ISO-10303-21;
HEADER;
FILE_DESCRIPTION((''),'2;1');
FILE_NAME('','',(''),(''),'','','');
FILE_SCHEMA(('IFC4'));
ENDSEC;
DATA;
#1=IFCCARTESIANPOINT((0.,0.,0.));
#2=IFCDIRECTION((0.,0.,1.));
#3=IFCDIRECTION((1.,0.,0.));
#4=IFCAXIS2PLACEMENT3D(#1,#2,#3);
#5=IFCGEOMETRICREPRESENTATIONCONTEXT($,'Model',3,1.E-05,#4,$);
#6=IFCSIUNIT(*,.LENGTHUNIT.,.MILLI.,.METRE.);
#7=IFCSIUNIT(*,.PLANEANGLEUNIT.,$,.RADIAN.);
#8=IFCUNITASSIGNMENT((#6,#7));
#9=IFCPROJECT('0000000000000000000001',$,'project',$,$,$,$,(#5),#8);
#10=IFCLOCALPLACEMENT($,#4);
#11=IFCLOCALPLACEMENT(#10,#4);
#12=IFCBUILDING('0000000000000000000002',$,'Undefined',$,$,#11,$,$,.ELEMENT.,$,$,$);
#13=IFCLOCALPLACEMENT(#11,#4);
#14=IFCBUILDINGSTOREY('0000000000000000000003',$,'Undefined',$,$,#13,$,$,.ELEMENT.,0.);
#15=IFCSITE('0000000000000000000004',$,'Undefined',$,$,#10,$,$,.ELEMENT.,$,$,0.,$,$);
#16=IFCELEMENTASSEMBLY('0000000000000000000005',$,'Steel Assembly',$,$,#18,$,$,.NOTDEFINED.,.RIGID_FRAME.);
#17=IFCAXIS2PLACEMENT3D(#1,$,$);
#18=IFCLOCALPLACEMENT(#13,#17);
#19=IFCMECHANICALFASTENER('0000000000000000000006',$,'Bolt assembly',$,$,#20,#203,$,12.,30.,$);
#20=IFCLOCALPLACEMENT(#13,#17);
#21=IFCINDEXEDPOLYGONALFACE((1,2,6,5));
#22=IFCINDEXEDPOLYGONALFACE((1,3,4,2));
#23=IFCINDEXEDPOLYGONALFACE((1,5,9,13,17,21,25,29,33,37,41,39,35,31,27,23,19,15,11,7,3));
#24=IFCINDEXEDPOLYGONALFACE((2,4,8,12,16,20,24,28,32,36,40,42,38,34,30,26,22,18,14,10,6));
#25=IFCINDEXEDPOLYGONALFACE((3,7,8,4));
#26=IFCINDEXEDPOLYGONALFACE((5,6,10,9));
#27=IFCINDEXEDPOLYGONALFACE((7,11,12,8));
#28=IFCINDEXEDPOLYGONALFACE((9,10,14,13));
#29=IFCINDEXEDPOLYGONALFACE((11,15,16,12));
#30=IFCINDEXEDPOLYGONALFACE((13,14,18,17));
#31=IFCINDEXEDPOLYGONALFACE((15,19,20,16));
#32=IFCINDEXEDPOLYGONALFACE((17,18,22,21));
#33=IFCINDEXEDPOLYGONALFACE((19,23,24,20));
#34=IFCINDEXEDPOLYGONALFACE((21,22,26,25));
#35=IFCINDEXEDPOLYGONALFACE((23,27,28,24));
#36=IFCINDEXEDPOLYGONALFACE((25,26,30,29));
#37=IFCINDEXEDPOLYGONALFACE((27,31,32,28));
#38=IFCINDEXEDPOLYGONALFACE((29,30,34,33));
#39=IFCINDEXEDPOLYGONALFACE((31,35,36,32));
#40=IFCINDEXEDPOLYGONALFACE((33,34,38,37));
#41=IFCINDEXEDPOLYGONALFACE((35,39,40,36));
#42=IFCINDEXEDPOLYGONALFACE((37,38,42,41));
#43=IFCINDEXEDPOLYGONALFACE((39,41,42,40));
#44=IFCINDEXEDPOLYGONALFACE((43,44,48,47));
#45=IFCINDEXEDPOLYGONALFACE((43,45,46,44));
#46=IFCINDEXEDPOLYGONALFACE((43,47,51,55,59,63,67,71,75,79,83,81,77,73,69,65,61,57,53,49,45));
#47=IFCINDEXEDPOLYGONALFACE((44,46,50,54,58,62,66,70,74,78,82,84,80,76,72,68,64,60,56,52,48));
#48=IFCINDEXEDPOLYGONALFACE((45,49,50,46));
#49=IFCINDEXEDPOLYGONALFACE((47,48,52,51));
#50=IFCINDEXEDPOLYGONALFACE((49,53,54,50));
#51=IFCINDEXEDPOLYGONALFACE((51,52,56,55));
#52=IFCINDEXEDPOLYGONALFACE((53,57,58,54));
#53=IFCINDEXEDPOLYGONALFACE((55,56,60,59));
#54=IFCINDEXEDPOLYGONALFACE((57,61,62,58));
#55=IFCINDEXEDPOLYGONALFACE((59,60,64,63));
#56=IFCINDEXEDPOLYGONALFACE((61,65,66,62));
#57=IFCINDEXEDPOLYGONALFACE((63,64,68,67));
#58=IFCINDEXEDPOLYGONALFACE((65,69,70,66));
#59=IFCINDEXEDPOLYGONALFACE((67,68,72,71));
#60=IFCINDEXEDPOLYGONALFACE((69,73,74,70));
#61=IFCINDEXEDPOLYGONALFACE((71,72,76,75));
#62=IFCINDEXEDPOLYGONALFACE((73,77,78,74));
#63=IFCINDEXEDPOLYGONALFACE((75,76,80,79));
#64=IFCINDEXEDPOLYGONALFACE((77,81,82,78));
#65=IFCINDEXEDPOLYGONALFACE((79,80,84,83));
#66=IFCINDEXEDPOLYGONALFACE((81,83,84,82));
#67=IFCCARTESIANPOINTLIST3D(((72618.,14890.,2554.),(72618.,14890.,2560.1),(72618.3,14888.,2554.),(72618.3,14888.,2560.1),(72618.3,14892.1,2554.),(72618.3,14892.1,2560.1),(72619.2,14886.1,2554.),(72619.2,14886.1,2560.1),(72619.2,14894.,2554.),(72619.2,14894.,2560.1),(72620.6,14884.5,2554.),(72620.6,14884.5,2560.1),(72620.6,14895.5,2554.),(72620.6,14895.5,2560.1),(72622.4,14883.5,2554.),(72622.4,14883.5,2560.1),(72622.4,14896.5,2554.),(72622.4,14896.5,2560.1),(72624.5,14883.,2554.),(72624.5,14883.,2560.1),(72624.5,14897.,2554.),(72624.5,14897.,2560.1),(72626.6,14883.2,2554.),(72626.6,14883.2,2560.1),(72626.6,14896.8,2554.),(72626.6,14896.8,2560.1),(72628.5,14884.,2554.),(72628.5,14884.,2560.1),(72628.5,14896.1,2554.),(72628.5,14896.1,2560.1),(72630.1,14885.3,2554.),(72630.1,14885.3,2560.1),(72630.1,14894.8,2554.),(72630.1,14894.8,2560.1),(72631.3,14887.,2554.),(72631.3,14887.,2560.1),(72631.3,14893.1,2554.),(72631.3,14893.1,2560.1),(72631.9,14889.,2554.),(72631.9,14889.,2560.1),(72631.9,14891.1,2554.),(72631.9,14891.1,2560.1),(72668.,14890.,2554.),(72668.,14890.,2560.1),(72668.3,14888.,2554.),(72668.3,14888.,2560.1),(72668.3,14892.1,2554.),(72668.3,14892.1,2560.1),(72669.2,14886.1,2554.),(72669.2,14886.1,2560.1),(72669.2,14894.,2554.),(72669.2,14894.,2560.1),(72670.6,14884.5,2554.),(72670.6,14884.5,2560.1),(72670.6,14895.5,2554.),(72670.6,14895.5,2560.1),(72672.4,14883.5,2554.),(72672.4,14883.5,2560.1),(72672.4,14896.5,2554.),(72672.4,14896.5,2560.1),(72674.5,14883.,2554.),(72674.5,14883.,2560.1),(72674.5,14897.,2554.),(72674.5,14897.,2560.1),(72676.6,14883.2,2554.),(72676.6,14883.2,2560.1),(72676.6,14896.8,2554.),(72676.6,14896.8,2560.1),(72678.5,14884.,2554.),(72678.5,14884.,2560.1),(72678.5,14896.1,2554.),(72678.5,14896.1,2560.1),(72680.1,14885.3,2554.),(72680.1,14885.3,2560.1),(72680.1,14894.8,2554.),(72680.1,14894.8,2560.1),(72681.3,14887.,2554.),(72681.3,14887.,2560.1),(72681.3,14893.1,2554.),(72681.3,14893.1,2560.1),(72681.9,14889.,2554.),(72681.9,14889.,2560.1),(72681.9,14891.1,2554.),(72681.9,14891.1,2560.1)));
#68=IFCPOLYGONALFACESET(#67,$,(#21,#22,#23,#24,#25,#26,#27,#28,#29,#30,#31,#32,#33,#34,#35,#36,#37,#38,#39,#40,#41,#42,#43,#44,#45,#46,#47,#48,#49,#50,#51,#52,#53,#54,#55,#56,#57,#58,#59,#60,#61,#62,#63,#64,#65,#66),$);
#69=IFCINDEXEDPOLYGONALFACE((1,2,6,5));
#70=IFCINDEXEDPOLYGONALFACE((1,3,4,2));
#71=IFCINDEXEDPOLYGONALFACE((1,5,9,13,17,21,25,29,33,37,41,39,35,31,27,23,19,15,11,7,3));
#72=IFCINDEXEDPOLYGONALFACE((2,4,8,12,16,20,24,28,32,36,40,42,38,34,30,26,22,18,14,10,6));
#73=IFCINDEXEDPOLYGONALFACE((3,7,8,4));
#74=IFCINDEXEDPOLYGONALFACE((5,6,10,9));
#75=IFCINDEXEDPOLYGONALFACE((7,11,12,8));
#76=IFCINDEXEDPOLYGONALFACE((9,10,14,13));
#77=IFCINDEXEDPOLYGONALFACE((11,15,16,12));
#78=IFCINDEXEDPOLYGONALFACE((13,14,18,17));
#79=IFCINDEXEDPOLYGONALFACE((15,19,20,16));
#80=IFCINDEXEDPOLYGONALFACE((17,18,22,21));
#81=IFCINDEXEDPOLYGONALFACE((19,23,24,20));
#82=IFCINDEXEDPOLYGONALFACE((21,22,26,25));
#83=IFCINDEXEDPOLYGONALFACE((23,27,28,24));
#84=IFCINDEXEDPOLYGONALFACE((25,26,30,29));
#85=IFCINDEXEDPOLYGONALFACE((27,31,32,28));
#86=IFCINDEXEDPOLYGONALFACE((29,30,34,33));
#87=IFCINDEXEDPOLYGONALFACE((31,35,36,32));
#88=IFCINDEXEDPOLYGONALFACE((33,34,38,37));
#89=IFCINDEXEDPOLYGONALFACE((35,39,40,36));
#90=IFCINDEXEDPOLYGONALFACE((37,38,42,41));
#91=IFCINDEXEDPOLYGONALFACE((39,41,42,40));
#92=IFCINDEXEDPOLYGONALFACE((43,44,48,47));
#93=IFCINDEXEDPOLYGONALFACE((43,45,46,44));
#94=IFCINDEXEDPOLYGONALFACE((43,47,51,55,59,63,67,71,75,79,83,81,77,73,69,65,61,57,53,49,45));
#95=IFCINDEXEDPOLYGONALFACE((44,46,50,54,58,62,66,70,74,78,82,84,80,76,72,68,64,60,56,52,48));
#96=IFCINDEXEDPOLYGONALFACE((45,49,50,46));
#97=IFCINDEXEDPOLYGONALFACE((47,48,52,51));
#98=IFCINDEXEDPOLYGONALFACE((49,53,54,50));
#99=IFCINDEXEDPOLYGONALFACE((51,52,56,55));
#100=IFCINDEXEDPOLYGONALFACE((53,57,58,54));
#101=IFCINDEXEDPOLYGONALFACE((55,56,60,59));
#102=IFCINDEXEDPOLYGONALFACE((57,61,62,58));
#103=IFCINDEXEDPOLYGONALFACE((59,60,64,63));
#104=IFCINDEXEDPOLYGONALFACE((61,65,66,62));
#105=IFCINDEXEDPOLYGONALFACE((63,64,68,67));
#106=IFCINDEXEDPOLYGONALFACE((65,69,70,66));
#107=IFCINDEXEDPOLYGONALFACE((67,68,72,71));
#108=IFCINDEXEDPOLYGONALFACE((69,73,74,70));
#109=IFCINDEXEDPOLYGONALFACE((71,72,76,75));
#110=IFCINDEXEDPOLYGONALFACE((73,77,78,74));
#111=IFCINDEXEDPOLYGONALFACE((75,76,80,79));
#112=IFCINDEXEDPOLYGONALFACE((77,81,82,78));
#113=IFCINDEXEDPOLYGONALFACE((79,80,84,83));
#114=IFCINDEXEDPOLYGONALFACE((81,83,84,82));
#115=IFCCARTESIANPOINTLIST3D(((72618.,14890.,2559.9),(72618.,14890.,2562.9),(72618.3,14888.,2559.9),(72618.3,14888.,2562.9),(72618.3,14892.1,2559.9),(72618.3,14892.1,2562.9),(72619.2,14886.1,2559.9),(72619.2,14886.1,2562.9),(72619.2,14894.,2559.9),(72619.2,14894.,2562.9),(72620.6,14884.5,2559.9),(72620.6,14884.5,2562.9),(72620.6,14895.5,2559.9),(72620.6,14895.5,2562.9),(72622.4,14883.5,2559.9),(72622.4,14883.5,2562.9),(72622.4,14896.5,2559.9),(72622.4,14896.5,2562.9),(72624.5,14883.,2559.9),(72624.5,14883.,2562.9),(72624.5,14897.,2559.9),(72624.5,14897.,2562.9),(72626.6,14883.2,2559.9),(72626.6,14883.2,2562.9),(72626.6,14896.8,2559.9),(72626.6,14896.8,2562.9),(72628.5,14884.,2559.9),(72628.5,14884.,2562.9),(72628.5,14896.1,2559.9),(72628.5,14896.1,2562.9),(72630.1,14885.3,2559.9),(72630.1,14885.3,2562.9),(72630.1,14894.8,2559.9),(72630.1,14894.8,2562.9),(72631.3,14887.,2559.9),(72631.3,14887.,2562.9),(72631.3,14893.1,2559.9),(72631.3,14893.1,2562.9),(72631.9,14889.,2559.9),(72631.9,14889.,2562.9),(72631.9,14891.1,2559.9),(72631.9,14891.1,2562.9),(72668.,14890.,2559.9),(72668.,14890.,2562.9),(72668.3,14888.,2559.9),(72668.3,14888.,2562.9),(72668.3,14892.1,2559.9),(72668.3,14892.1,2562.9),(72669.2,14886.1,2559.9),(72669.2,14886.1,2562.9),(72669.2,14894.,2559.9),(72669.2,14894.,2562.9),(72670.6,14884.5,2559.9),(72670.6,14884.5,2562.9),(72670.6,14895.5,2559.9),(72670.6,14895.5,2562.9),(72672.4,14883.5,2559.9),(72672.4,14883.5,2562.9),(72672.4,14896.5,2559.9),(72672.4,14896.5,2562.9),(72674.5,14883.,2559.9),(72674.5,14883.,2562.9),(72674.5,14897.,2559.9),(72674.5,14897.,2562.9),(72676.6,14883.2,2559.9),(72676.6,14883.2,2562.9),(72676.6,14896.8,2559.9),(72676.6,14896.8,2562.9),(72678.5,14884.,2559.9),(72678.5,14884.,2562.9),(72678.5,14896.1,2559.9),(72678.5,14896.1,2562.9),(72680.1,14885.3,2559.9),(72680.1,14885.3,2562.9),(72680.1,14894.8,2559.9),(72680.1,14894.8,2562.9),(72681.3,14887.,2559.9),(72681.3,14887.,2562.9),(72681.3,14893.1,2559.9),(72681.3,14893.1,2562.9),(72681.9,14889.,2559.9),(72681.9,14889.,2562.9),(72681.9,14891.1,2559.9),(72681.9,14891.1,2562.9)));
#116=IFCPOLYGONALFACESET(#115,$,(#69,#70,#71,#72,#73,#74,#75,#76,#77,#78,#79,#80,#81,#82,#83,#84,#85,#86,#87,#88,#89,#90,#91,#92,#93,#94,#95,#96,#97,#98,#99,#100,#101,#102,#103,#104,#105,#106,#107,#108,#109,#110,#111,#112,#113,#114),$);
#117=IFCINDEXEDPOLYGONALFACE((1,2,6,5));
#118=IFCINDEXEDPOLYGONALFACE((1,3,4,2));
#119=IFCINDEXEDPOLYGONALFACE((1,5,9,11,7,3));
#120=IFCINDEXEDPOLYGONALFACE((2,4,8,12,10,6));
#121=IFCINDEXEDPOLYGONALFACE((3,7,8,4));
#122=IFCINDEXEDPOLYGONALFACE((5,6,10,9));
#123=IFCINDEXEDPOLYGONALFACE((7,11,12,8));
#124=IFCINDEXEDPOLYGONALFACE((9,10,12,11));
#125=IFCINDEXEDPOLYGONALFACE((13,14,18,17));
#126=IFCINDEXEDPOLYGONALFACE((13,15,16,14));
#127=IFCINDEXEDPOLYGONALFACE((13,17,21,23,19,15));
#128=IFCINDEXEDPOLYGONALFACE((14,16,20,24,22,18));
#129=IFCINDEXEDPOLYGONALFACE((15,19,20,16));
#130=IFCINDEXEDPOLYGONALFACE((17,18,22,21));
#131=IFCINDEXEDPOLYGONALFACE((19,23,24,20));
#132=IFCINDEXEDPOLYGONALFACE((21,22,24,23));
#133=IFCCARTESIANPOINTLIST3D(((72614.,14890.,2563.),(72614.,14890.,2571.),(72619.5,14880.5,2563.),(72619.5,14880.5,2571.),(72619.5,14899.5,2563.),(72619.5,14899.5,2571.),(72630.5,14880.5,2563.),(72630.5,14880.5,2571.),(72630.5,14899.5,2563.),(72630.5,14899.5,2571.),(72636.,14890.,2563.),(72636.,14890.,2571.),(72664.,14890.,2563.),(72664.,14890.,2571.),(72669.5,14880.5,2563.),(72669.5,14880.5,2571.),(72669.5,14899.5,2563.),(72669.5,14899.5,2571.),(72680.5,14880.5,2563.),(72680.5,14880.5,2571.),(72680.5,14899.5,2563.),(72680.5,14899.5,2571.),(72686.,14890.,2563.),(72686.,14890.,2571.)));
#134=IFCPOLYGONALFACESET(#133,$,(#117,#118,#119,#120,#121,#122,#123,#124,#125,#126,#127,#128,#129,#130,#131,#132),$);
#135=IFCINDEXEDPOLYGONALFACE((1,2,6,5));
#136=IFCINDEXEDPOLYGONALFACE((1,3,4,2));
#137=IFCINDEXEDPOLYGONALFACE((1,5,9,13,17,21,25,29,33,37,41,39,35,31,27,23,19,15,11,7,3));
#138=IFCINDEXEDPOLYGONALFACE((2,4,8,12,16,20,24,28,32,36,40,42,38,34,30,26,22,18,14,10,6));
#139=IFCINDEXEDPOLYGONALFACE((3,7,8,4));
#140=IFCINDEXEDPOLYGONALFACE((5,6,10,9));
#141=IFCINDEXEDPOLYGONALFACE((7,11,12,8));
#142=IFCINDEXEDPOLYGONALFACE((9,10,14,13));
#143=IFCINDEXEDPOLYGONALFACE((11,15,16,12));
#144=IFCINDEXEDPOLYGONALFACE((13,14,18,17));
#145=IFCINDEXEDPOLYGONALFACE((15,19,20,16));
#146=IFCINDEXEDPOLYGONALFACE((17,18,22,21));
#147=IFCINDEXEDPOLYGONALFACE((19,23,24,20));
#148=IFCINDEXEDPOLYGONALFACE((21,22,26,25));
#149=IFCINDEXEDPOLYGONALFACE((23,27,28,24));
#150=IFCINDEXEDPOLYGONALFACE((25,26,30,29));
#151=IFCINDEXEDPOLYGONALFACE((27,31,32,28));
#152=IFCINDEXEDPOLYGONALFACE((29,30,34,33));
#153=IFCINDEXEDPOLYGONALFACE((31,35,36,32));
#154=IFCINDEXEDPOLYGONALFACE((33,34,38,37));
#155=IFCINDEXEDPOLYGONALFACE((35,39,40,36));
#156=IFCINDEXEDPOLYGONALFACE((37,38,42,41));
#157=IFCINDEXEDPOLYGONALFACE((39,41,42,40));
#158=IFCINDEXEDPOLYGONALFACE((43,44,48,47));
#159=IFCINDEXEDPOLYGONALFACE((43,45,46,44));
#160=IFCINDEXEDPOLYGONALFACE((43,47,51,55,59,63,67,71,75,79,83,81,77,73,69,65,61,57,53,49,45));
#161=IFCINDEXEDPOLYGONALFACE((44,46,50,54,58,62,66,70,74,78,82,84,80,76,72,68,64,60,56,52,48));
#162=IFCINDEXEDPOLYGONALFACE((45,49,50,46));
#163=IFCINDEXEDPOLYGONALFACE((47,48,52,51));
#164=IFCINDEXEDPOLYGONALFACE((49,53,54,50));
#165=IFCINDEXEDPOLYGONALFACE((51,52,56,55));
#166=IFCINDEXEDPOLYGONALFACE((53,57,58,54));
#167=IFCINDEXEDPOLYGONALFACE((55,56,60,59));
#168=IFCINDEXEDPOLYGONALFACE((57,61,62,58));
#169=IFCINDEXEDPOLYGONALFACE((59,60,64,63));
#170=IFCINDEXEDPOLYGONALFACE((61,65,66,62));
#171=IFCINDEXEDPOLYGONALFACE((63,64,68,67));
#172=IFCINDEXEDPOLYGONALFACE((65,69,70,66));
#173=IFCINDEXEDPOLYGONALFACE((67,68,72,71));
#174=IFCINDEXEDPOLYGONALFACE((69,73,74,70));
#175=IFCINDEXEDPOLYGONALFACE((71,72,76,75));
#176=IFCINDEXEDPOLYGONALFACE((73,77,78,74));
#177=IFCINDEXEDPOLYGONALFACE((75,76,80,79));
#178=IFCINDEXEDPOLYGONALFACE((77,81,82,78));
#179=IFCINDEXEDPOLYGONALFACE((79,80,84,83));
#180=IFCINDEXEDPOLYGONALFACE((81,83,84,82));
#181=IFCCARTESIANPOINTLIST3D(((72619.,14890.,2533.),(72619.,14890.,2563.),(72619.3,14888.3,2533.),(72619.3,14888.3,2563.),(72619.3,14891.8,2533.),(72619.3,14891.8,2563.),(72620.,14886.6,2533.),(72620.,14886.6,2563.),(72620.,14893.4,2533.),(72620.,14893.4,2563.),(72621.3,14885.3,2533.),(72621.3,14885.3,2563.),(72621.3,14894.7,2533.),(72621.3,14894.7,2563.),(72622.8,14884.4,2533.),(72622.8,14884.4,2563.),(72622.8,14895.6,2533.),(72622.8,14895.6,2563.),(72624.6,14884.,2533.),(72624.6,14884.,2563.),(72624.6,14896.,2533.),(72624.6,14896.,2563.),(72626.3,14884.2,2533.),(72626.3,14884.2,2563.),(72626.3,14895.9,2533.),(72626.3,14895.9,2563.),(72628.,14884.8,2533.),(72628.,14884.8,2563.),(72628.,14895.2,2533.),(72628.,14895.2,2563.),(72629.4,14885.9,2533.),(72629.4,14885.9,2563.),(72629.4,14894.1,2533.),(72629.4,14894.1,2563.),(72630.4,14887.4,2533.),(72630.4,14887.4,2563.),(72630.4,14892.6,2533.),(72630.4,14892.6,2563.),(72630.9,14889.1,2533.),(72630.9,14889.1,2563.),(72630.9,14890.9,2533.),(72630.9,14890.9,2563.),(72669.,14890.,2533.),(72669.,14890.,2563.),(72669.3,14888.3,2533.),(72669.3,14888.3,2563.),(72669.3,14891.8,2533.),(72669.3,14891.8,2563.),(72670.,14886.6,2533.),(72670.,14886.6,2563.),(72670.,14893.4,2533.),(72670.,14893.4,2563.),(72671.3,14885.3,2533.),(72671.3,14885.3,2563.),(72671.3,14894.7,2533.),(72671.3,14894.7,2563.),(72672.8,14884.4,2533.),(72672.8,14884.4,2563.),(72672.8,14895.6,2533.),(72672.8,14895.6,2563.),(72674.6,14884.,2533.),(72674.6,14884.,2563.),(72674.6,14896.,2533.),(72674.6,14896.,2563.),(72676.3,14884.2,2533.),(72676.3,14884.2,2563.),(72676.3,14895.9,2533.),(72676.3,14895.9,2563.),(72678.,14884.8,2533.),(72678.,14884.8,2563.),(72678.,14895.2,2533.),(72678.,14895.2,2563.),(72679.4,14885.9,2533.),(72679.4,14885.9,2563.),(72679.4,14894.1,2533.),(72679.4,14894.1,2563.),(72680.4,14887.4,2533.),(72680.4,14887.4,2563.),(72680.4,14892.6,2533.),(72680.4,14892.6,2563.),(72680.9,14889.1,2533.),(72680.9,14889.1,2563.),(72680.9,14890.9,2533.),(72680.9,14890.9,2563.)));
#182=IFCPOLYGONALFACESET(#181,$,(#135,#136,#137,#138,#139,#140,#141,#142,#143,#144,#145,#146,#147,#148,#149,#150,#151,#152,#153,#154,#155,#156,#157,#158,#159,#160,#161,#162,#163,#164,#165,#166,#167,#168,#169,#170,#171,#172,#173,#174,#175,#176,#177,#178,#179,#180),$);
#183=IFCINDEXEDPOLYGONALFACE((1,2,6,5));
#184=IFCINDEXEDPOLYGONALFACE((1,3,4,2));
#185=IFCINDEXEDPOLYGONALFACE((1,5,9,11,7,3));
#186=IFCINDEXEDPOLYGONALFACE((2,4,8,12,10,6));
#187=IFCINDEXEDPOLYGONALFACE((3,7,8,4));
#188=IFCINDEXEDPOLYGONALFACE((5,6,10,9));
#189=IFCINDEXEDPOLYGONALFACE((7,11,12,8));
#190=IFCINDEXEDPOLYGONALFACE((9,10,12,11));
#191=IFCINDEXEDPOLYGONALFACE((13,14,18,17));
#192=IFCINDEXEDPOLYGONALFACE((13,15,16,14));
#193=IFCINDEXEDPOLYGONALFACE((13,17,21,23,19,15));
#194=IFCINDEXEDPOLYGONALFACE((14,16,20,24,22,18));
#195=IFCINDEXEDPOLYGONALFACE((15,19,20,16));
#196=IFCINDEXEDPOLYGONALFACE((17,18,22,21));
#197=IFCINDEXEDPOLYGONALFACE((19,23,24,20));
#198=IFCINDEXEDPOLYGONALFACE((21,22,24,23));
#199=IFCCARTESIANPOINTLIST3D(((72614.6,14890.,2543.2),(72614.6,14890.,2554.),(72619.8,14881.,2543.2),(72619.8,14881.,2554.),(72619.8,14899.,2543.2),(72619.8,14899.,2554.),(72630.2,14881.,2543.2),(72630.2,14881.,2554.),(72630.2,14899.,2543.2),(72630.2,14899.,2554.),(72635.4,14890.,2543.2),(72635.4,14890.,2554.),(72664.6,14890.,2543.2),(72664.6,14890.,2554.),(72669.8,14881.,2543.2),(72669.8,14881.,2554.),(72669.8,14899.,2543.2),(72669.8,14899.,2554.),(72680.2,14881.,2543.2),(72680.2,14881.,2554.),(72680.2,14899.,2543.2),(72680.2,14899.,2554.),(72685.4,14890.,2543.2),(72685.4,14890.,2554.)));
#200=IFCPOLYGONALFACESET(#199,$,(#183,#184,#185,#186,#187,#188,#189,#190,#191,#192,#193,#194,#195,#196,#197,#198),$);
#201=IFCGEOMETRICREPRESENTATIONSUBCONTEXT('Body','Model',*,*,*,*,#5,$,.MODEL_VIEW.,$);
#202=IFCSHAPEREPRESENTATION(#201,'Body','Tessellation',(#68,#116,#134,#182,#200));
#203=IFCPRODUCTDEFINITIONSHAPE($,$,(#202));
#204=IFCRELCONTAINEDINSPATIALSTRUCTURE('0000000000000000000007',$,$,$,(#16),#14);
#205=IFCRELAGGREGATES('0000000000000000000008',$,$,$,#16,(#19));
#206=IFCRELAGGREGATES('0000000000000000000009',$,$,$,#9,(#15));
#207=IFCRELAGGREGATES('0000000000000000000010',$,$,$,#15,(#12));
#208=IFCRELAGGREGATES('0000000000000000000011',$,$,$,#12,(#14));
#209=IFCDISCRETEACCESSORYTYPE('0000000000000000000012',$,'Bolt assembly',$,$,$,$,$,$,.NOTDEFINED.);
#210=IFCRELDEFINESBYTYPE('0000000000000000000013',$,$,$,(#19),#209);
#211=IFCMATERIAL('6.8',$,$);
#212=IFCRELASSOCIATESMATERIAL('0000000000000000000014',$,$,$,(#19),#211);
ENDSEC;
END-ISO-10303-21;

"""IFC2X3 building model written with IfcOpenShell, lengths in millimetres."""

from ifc_helpers import new_model, si_unit, frame, origin_with_axes, origin_2d_with_axis, place, context, subcontext, project, spatial, polyline, circle, outline, extrude, source, transform, mapped, material, type_object, element, aggregate, save


model = new_model("IFC2X3")

# Units and contexts
model_context = context("Model", 3, precision=1e-05, world=origin_with_axes())
body_context = subcontext(model_context, "Body", "Model", "MODEL_VIEW")
ifc_project = project(units=[si_unit("LENGTHUNIT", "METRE", prefix="MILLI"), si_unit("PLANEANGLEUNIT", "RADIAN")], contexts=[model_context])

# Site, building, storey
site_placement = place(None, origin_with_axes())
site = spatial("IfcSite", under=ifc_project, at=site_placement, Name="Undefined", CompositionType="ELEMENT", RefElevation=0.0)
building_placement = place(site_placement, origin_with_axes())
building = spatial("IfcBuilding", under=site, at=building_placement, Name="Undefined", CompositionType="ELEMENT")
storey_placement = place(building_placement, origin_with_axes())
storey = spatial("IfcBuildingStorey", under=building, at=storey_placement, Name="Undefined", CompositionType="ELEMENT", Elevation=0.0)

# Element assembly
assembly_1_placement = place(storey_placement, origin_with_axes())
assembly_1 = element("IfcElementAssembly", 1, at=assembly_1_placement, inside=storey, Name="Steel Assembly", AssemblyPlace="NOTDEFINED", PredefinedType="RIGID_FRAME")

# Shared definitions
ifc_material_1 = material(Name="6.8")
discrete_accessory_type_1 = type_object("IfcDiscreteAccessoryType", Name="Bolt assembly")

# Mechanical fastener
shared_shape_1 = source(origin_with_axes(), body_context, "Body", "SweptSolid", [
    extrude(circle(Radius=7.0, at=origin_2d_with_axis()), frame((0.0, -6.1, 0.0), z_axis=(0.0, 1.0, 0.0), x_axis=(1.0, 0.0, 0.0)), (0.0, 0.0, 1.0), 6.1),
    extrude(circle(Radius=7.0, at=origin_2d_with_axis()), frame((0.0, -8.9, 0.0), z_axis=(0.0, 1.0, 0.0), x_axis=(1.0, 0.0, 0.0)), (0.0, 0.0, 1.0), 3.0),
    extrude(outline(polyline([(11.0, 0.0), (5.5, 9.5), (-5.5, 9.5), (-11.0, 0.0), (-5.5, -9.5), (5.5, -9.5), (11.0, 0.0)])), frame((0.0, -17.0, 0.0), z_axis=(0.0, 1.0, 0.0), x_axis=(1.0, 0.0, 0.0)), (0.0, 0.0, 1.0), 8.0),
    extrude(circle(Radius=6.0, at=origin_2d_with_axis()), frame((0.0, -9.0, 0.0), z_axis=(0.0, 1.0, 0.0), x_axis=(1.0, 0.0, 0.0)), (0.0, 0.0, 1.0), 30.0),
    extrude(outline(polyline([(10.4, 0.0), (5.2, 9.0), (-5.2, 9.0), (-10.4, 0.0), (-5.2, -9.0), (5.2, -9.0), (10.4, 0.0)])), frame((0.0, 0.0, 0.0), z_axis=(0.0, 1.0, 0.0), x_axis=(1.0, 0.0, 0.0)), (0.0, 0.0, 1.0), 10.8),
])
mechanical_fastener_1_placement = place(assembly_1_placement, frame((72675.0, 14890.0, 2554.0), z_axis=(0.0, -1.0, 0.0), x_axis=(-1.0, 0.0, 0.0)))
mechanical_fastener_1 = element("IfcMechanicalFastener", 2, at=mechanical_fastener_1_placement, type_object=discrete_accessory_type_1, material=ifc_material_1, Name="Bolt assembly", NominalDiameter=12.0, NominalLength=30.0, context=body_context, shape_type="MappedRepresentation", body=[
    mapped(shared_shape_1, transform((0.0, 0.0, 0.0))),
    mapped(shared_shape_1, transform((50.0, 0.0, 0.0))),
])
aggregate(assembly_1, [mechanical_fastener_1])

save(model, "model.ifc")
